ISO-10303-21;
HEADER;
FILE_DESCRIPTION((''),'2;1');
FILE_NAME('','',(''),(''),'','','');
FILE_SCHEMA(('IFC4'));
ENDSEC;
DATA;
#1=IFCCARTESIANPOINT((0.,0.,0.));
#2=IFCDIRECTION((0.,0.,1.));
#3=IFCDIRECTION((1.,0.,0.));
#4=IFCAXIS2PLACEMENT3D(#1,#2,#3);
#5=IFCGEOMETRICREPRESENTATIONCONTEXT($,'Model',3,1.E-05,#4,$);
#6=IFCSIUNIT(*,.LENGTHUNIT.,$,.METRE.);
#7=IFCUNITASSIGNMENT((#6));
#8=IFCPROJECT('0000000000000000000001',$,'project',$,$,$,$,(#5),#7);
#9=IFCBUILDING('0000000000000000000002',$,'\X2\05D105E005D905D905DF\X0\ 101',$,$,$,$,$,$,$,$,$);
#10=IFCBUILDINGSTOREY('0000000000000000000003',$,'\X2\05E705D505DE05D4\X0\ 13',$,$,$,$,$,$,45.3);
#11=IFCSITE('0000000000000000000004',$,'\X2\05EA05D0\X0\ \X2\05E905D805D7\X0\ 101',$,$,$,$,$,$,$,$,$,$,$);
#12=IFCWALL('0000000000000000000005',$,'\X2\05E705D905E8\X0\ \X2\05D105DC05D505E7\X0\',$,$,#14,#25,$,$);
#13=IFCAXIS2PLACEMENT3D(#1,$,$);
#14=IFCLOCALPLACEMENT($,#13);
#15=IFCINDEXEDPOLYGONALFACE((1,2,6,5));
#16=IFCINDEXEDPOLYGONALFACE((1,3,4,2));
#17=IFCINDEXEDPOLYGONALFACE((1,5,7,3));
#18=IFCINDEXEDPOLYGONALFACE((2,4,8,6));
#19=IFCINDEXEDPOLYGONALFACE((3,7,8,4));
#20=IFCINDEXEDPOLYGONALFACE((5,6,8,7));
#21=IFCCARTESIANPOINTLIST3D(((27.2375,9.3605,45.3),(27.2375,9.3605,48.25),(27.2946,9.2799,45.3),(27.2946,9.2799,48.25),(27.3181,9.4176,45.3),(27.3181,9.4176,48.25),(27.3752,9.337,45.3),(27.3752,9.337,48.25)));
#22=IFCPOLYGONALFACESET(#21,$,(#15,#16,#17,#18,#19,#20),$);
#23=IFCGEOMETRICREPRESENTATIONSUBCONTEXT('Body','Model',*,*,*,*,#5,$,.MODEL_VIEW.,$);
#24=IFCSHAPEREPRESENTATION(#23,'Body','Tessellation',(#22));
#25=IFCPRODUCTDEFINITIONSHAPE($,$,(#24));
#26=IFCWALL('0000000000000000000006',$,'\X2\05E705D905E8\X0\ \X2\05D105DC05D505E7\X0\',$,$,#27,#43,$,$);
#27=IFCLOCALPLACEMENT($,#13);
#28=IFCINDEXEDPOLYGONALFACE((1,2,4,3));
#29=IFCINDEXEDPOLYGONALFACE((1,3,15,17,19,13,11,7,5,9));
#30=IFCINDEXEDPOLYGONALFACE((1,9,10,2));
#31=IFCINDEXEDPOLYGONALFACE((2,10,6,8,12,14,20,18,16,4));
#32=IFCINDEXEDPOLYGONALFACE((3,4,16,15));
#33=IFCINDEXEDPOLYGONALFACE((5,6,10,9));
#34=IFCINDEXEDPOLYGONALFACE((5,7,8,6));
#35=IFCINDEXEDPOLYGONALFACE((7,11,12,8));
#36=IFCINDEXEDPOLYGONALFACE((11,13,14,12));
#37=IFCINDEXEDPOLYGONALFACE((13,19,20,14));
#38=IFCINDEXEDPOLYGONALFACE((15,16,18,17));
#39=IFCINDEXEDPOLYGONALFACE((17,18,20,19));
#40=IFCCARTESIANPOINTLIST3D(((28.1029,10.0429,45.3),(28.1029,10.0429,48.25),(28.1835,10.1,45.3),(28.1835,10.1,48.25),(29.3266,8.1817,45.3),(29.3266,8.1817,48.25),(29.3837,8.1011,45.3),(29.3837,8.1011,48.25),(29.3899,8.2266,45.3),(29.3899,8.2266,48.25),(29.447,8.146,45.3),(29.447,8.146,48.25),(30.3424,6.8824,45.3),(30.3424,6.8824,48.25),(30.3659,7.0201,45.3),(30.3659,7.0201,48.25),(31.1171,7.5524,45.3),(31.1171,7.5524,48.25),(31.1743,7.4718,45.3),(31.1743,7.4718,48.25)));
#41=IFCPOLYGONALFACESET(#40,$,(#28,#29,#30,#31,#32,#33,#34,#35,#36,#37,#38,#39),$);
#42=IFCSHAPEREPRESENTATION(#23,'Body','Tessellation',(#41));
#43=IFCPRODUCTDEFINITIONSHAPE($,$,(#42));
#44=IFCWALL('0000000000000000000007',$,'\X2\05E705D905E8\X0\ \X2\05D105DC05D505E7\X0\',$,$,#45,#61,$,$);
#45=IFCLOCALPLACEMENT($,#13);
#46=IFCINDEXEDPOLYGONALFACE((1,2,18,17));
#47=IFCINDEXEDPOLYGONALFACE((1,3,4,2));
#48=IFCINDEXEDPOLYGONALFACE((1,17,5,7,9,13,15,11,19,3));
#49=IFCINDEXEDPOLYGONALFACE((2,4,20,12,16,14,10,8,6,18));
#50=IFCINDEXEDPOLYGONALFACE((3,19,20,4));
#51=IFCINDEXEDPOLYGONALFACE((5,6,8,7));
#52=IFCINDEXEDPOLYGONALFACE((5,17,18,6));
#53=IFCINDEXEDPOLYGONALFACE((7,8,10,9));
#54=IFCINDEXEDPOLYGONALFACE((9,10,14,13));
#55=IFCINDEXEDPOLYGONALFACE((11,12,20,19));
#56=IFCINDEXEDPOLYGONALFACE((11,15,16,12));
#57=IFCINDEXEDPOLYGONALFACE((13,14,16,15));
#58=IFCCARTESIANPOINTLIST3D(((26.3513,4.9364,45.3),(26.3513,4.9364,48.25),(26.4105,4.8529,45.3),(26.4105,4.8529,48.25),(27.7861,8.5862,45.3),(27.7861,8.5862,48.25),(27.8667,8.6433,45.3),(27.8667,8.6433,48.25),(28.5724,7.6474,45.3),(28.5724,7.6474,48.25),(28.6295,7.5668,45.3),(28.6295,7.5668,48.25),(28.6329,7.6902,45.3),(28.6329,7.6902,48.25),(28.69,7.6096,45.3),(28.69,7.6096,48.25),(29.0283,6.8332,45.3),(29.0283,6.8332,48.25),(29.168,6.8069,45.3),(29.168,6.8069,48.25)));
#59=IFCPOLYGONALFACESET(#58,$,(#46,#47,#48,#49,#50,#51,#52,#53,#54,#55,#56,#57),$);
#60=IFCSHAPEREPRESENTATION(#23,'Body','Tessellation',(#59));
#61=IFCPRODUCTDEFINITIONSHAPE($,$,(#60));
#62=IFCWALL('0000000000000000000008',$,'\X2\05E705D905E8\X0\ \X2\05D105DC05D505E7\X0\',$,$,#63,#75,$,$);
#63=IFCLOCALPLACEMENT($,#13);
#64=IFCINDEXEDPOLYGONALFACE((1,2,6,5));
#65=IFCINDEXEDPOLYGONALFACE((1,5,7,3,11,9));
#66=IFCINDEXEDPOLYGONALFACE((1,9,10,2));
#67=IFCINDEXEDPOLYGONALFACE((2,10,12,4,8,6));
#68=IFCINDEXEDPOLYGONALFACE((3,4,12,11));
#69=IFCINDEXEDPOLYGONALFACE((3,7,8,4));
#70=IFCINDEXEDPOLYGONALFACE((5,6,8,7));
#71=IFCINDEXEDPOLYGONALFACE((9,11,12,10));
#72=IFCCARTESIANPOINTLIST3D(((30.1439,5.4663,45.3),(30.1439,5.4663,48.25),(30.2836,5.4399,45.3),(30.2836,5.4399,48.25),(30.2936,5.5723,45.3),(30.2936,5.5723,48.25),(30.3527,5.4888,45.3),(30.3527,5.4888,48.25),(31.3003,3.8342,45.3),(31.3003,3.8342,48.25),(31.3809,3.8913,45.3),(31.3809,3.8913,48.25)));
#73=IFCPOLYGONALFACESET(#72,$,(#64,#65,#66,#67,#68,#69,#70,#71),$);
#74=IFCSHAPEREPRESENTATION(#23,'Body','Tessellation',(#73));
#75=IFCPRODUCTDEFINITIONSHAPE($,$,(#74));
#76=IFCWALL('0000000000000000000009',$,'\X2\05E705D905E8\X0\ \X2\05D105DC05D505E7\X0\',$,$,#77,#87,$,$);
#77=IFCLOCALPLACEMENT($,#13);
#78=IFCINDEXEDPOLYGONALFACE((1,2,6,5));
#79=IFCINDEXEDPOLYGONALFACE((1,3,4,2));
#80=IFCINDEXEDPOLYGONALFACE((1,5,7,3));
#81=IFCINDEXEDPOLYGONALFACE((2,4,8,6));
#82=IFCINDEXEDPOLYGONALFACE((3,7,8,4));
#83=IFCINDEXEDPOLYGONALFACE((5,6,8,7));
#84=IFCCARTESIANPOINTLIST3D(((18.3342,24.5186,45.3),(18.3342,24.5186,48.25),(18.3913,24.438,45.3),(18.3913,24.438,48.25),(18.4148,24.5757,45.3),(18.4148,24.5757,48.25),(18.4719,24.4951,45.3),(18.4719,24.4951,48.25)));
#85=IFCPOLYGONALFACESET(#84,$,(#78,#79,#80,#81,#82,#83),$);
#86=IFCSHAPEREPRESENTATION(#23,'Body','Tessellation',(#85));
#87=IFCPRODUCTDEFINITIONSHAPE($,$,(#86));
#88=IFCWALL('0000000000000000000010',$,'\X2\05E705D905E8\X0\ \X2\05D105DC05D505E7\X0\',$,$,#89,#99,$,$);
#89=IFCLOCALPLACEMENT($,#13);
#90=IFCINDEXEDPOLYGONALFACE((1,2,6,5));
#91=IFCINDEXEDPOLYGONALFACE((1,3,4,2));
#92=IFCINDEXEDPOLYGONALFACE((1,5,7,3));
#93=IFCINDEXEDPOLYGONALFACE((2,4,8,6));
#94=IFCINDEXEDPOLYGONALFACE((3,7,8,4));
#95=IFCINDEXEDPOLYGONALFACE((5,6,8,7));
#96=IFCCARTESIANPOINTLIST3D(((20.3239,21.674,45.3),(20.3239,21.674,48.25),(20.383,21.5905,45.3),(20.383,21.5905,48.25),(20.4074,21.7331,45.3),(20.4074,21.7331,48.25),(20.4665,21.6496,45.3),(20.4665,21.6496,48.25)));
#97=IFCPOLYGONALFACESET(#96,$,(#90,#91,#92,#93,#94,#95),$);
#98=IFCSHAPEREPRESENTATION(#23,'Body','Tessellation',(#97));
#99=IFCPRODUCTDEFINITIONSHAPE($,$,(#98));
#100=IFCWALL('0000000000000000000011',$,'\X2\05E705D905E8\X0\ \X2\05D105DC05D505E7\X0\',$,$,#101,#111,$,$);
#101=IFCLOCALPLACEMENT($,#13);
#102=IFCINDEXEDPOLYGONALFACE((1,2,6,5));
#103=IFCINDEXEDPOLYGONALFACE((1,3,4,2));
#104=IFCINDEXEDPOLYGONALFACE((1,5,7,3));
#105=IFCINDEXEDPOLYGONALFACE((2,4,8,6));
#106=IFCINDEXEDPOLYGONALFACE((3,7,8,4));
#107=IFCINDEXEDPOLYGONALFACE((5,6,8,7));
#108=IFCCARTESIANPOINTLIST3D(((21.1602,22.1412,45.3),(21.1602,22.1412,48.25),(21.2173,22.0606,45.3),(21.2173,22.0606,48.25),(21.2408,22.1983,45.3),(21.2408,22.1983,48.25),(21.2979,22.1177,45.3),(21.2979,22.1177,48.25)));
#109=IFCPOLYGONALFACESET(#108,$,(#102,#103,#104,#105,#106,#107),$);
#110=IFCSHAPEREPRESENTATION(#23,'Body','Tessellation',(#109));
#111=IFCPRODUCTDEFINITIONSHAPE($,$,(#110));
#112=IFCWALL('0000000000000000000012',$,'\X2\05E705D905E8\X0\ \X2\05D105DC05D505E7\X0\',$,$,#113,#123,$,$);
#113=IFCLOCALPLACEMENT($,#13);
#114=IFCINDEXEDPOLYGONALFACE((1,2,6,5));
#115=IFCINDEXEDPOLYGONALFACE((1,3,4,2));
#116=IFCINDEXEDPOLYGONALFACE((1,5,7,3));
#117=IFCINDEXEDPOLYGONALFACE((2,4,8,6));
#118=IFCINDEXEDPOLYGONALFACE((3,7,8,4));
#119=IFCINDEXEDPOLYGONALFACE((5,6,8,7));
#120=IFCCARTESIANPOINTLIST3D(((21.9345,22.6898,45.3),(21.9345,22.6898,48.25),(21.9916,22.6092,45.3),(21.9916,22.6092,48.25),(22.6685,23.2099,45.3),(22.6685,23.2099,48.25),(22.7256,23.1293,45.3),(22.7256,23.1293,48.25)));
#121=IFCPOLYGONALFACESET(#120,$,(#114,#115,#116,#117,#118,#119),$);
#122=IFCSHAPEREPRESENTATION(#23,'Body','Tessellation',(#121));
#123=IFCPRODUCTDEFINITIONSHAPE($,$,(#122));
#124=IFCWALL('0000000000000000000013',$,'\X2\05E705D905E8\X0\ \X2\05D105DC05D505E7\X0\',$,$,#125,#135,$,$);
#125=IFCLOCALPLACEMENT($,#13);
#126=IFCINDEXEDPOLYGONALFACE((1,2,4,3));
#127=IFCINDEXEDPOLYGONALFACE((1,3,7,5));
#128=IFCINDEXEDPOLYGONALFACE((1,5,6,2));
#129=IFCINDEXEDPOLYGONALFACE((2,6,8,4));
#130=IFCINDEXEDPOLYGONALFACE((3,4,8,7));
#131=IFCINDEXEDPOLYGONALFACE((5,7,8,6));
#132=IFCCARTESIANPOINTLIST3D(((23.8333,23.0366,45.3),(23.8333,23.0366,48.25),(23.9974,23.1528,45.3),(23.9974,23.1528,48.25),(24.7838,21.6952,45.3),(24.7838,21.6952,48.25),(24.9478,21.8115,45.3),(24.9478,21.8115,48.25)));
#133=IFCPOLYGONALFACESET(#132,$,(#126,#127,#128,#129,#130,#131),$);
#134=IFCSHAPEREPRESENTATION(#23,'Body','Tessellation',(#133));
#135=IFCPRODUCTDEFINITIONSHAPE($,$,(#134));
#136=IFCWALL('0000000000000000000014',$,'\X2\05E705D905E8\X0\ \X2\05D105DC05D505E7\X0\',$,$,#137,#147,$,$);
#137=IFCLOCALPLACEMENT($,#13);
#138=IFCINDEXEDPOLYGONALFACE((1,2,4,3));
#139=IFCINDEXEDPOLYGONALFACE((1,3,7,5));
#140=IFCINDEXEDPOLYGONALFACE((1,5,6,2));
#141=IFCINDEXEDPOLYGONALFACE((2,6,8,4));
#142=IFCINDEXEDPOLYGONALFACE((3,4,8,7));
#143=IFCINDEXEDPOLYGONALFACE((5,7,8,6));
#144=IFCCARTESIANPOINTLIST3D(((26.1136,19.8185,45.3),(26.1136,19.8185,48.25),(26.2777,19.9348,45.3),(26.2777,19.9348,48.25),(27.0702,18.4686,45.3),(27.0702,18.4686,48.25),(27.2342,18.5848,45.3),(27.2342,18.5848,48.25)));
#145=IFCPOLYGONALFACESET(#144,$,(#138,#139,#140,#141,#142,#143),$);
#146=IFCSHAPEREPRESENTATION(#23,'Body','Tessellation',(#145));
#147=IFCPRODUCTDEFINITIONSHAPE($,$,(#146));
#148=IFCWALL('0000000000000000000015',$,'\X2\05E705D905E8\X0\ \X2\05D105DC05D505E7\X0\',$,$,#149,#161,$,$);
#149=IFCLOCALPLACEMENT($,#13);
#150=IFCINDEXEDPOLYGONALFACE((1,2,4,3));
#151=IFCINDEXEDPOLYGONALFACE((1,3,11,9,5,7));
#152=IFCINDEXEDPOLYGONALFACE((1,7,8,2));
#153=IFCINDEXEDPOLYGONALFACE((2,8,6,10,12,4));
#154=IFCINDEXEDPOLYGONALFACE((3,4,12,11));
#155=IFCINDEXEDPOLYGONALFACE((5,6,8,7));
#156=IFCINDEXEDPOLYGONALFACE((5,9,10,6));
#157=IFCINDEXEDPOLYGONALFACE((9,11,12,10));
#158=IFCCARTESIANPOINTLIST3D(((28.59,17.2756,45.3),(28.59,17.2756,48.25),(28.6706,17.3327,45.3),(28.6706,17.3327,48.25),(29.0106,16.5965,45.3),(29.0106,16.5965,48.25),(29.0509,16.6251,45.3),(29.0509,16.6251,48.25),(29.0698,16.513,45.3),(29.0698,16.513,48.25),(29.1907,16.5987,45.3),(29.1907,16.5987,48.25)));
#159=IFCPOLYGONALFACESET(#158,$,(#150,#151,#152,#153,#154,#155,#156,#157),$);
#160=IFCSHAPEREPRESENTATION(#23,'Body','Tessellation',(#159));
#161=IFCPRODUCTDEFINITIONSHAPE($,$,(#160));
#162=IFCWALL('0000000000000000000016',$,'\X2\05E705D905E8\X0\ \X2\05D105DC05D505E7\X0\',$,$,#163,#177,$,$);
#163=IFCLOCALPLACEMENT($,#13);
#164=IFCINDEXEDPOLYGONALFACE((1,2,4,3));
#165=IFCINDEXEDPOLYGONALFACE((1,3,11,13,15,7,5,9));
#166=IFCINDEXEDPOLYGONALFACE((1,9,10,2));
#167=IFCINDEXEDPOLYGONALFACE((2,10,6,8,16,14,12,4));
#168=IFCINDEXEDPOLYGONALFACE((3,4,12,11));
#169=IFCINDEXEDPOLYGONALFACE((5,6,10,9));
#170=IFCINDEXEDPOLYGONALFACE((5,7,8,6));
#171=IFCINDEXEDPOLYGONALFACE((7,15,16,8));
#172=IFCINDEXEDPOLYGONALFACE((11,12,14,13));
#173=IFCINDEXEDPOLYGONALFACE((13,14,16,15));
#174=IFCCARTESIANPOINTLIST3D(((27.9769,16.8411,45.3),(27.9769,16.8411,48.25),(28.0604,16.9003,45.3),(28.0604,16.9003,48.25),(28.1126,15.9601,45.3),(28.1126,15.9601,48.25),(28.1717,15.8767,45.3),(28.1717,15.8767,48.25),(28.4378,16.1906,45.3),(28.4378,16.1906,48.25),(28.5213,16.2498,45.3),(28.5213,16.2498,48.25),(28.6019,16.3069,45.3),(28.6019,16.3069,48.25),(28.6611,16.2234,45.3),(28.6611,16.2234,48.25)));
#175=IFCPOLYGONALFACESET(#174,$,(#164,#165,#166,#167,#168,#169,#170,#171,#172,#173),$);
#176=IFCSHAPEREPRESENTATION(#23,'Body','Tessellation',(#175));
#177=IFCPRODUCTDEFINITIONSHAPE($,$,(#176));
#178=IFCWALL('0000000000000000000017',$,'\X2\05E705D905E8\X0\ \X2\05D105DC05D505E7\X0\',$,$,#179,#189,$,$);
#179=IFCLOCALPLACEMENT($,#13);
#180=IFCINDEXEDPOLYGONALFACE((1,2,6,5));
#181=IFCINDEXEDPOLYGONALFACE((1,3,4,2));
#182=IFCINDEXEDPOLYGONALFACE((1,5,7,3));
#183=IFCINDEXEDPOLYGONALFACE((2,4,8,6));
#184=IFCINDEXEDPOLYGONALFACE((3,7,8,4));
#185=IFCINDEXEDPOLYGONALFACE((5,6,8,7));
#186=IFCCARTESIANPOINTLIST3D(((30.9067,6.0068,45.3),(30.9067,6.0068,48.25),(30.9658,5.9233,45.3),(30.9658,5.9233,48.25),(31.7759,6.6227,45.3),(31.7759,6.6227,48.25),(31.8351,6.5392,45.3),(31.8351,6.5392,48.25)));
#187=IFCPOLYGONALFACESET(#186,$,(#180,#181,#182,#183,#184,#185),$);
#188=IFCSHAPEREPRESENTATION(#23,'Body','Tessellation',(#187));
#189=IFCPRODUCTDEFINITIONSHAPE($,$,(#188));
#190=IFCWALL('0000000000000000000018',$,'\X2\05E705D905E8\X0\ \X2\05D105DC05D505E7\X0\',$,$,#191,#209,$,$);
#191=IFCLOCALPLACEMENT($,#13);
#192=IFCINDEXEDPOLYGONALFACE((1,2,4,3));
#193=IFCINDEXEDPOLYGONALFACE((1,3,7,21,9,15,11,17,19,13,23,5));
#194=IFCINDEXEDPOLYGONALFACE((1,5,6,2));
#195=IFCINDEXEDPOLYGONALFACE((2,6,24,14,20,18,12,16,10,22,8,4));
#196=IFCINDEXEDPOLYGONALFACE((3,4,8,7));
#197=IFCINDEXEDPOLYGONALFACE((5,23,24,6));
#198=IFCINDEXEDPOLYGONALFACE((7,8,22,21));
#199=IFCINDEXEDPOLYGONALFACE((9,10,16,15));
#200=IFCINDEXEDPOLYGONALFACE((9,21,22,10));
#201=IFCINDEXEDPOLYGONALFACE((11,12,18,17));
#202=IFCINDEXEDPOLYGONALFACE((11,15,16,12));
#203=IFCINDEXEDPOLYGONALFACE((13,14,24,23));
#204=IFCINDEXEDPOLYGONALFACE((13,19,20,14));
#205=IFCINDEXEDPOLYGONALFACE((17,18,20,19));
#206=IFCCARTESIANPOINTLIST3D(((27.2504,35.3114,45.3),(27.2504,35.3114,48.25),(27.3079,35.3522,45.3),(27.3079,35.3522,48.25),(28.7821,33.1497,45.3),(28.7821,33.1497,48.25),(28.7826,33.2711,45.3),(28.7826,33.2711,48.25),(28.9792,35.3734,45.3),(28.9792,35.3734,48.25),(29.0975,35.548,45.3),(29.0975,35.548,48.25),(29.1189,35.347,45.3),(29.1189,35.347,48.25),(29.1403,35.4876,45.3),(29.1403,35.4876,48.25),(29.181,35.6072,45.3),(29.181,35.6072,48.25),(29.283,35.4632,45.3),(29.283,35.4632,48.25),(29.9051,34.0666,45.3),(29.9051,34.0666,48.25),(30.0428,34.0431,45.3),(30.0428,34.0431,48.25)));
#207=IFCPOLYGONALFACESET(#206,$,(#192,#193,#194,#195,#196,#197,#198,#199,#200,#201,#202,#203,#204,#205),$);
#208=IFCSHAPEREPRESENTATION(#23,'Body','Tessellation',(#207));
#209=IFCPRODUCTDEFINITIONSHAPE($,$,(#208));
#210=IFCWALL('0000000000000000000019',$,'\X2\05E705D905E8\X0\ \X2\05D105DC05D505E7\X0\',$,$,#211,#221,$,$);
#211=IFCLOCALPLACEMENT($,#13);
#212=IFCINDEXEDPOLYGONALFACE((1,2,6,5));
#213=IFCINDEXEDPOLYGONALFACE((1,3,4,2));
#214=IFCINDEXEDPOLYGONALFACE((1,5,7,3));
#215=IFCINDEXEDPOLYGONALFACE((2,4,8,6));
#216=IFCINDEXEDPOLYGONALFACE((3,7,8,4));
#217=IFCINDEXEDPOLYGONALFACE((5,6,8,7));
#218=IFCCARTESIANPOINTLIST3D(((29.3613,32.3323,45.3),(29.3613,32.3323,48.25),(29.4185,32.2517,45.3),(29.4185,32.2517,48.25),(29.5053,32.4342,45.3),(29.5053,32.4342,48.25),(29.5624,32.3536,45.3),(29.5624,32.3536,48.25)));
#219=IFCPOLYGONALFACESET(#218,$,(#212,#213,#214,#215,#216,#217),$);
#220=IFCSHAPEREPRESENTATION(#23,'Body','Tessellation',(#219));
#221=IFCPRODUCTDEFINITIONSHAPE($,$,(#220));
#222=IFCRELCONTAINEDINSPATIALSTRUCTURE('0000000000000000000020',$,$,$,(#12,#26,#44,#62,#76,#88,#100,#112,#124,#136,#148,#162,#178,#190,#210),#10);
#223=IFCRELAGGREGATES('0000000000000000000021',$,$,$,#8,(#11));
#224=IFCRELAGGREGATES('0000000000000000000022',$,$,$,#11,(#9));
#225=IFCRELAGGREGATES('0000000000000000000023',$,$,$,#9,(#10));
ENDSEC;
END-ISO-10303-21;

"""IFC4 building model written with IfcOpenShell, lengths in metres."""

from ifc_helpers import new_model, si_unit, frame, origin_with_axes, context, subcontext, project, spatial, polyline, outline, extrude, element, save


model = new_model("IFC4")

# Units and contexts
model_context = context("Model", 3, precision=1e-05, world=origin_with_axes())
body_context = subcontext(model_context, "Body", "Model", "MODEL_VIEW")
ifc_project = project(units=[si_unit("LENGTHUNIT", "METRE")], contexts=[model_context])

# Site, building, storey
site = spatial("IfcSite", under=ifc_project, Name="תא שטח 101")
building = spatial("IfcBuilding", under=site, Name="בניין 101")
storey = spatial("IfcBuildingStorey", under=building, Name="קומה 13", Elevation=45.3)

# Walls
element("IfcWall", 1, inside=storey, Name="קיר בלוק", context=body_context, shape_type="SweptSolid", body=[
    extrude(outline(polyline([(27.3181, 9.4176), (27.2375, 9.3605), (27.2946, 9.2799), (27.3752, 9.337), (27.3181, 9.4176)])), frame((0.0, 0.0, 45.3)), (0.0, 0.0, 1.0), 2.95),
])
element("IfcWall", 2, inside=storey, Name="קיר בלוק", context=body_context, shape_type="SweptSolid", body=[
    extrude(outline(polyline([(29.3266, 8.1817), (29.3837, 8.1011), (29.447, 8.146), (30.3424, 6.8824), (31.1743, 7.4718), (31.1171, 7.5524), (30.3659, 7.0201), (28.1835, 10.1), (28.1029, 10.0429), (29.3899, 8.2266), (29.3266, 8.1817)])), frame((0.0, 0.0, 45.3)), (0.0, 0.0, 1.0), 2.95),
])
element("IfcWall", 3, inside=storey, Name="קיר בלוק", context=body_context, shape_type="SweptSolid", body=[
    extrude(outline(polyline([(26.4105, 4.8529), (29.168, 6.8069), (28.6295, 7.5668), (28.69, 7.6096), (28.6329, 7.6902), (28.5724, 7.6474), (27.8667, 8.6433), (27.7861, 8.5862), (29.0283, 6.8332), (26.3513, 4.9364), (26.4105, 4.8529)])), frame((0.0, 0.0, 45.3)), (0.0, 0.0, 1.0), 2.95),
])
element("IfcWall", 4, inside=storey, Name="קיר בלוק", context=body_context, shape_type="SweptSolid", body=[
    extrude(outline(polyline([(30.2836, 5.4399), (30.3527, 5.4888), (30.2936, 5.5723), (30.1439, 5.4663), (31.3003, 3.8342), (31.3809, 3.8913), (30.2836, 5.4399)])), frame((0.0, 0.0, 45.3)), (0.0, 0.0, 1.0), 2.95),
])
element("IfcWall", 5, inside=storey, Name="קיר בלוק", context=body_context, shape_type="SweptSolid", body=[
    extrude(outline(polyline([(18.3913, 24.438), (18.4719, 24.4951), (18.4148, 24.5757), (18.3342, 24.5186), (18.3913, 24.438)])), frame((0.0, 0.0, 45.3)), (0.0, 0.0, 1.0), 2.95),
])
element("IfcWall", 6, inside=storey, Name="קיר בלוק", context=body_context, shape_type="SweptSolid", body=[
    extrude(outline(polyline([(20.4074, 21.7331), (20.3239, 21.674), (20.383, 21.5905), (20.4665, 21.6496), (20.4074, 21.7331)])), frame((0.0, 0.0, 45.3)), (0.0, 0.0, 1.0), 2.95),
])
element("IfcWall", 7, inside=storey, Name="קיר בלוק", context=body_context, shape_type="SweptSolid", body=[
    extrude(outline(polyline([(21.2979, 22.1177), (21.2408, 22.1983), (21.1602, 22.1412), (21.2173, 22.0606), (21.2979, 22.1177)])), frame((0.0, 0.0, 45.3)), (0.0, 0.0, 1.0), 2.95),
])
element("IfcWall", 8, inside=storey, Name="קיר בלוק", context=body_context, shape_type="SweptSolid", body=[
    extrude(outline(polyline([(22.7256, 23.1293), (22.6685, 23.2099), (21.9345, 22.6898), (21.9916, 22.6092), (22.7256, 23.1293)])), frame((0.0, 0.0, 45.3)), (0.0, 0.0, 1.0), 2.95),
])
element("IfcWall", 9, inside=storey, Name="קיר בלוק", context=body_context, shape_type="SweptSolid", body=[
    extrude(outline(polyline([(23.9974, 23.1528), (23.8333, 23.0366), (24.7838, 21.6952), (24.9478, 21.8115), (23.9974, 23.1528)])), frame((0.0, 0.0, 45.3)), (0.0, 0.0, 1.0), 2.95),
])
element("IfcWall", 10, inside=storey, Name="קיר בלוק", context=body_context, shape_type="SweptSolid", body=[
    extrude(outline(polyline([(27.0702, 18.4686), (27.2342, 18.5848), (26.2777, 19.9348), (26.1136, 19.8185), (27.0702, 18.4686)])), frame((0.0, 0.0, 45.3)), (0.0, 0.0, 1.0), 2.95),
])
element("IfcWall", 11, inside=storey, Name="קיר בלוק", context=body_context, shape_type="SweptSolid", body=[
    extrude(outline(polyline([(29.0106, 16.5965), (29.0698, 16.513), (29.1907, 16.5987), (28.6706, 17.3327), (28.59, 17.2756), (29.0509, 16.6251), (29.0106, 16.5965)])), frame((0.0, 0.0, 45.3)), (0.0, 0.0, 1.0), 2.95),
])
element("IfcWall", 12, inside=storey, Name="קיר בלוק", context=body_context, shape_type="SweptSolid", body=[
    extrude(outline(polyline([(28.1717, 15.8767), (28.6611, 16.2234), (28.6019, 16.3069), (28.5213, 16.2498), (28.0604, 16.9003), (27.9769, 16.8411), (28.4378, 16.1906), (28.1126, 15.9601), (28.1717, 15.8767)])), frame((0.0, 0.0, 45.3)), (0.0, 0.0, 1.0), 2.95),
])
element("IfcWall", 13, inside=storey, Name="קיר בלוק", context=body_context, shape_type="SweptSolid", body=[
    extrude(outline(polyline([(31.7759, 6.6227), (30.9067, 6.0068), (30.9658, 5.9233), (31.8351, 6.5392), (31.7759, 6.6227)])), frame((0.0, 0.0, 45.3)), (0.0, 0.0, 1.0), 2.95),
])
element("IfcWall", 14, inside=storey, Name="קיר בלוק", context=body_context, shape_type="SweptSolid", body=[
    extrude(outline(polyline([(27.2504, 35.3114), (28.7821, 33.1497), (30.0428, 34.0431), (29.1189, 35.347), (29.283, 35.4632), (29.181, 35.6072), (29.0975, 35.548), (29.1403, 35.4876), (28.9792, 35.3734), (29.9051, 34.0666), (28.7826, 33.2711), (27.3079, 35.3522), (27.2504, 35.3114)])), frame((0.0, 0.0, 45.3)), (0.0, 0.0, 1.0), 2.95),
])
element("IfcWall", 15, inside=storey, Name="קיר בלוק", context=body_context, shape_type="SweptSolid", body=[
    extrude(outline(polyline([(29.3613, 32.3323), (29.4185, 32.2517), (29.5624, 32.3536), (29.5053, 32.4342), (29.3613, 32.3323)])), frame((0.0, 0.0, 45.3)), (0.0, 0.0, 1.0), 2.95),
])

save(model, "model.ifc")
